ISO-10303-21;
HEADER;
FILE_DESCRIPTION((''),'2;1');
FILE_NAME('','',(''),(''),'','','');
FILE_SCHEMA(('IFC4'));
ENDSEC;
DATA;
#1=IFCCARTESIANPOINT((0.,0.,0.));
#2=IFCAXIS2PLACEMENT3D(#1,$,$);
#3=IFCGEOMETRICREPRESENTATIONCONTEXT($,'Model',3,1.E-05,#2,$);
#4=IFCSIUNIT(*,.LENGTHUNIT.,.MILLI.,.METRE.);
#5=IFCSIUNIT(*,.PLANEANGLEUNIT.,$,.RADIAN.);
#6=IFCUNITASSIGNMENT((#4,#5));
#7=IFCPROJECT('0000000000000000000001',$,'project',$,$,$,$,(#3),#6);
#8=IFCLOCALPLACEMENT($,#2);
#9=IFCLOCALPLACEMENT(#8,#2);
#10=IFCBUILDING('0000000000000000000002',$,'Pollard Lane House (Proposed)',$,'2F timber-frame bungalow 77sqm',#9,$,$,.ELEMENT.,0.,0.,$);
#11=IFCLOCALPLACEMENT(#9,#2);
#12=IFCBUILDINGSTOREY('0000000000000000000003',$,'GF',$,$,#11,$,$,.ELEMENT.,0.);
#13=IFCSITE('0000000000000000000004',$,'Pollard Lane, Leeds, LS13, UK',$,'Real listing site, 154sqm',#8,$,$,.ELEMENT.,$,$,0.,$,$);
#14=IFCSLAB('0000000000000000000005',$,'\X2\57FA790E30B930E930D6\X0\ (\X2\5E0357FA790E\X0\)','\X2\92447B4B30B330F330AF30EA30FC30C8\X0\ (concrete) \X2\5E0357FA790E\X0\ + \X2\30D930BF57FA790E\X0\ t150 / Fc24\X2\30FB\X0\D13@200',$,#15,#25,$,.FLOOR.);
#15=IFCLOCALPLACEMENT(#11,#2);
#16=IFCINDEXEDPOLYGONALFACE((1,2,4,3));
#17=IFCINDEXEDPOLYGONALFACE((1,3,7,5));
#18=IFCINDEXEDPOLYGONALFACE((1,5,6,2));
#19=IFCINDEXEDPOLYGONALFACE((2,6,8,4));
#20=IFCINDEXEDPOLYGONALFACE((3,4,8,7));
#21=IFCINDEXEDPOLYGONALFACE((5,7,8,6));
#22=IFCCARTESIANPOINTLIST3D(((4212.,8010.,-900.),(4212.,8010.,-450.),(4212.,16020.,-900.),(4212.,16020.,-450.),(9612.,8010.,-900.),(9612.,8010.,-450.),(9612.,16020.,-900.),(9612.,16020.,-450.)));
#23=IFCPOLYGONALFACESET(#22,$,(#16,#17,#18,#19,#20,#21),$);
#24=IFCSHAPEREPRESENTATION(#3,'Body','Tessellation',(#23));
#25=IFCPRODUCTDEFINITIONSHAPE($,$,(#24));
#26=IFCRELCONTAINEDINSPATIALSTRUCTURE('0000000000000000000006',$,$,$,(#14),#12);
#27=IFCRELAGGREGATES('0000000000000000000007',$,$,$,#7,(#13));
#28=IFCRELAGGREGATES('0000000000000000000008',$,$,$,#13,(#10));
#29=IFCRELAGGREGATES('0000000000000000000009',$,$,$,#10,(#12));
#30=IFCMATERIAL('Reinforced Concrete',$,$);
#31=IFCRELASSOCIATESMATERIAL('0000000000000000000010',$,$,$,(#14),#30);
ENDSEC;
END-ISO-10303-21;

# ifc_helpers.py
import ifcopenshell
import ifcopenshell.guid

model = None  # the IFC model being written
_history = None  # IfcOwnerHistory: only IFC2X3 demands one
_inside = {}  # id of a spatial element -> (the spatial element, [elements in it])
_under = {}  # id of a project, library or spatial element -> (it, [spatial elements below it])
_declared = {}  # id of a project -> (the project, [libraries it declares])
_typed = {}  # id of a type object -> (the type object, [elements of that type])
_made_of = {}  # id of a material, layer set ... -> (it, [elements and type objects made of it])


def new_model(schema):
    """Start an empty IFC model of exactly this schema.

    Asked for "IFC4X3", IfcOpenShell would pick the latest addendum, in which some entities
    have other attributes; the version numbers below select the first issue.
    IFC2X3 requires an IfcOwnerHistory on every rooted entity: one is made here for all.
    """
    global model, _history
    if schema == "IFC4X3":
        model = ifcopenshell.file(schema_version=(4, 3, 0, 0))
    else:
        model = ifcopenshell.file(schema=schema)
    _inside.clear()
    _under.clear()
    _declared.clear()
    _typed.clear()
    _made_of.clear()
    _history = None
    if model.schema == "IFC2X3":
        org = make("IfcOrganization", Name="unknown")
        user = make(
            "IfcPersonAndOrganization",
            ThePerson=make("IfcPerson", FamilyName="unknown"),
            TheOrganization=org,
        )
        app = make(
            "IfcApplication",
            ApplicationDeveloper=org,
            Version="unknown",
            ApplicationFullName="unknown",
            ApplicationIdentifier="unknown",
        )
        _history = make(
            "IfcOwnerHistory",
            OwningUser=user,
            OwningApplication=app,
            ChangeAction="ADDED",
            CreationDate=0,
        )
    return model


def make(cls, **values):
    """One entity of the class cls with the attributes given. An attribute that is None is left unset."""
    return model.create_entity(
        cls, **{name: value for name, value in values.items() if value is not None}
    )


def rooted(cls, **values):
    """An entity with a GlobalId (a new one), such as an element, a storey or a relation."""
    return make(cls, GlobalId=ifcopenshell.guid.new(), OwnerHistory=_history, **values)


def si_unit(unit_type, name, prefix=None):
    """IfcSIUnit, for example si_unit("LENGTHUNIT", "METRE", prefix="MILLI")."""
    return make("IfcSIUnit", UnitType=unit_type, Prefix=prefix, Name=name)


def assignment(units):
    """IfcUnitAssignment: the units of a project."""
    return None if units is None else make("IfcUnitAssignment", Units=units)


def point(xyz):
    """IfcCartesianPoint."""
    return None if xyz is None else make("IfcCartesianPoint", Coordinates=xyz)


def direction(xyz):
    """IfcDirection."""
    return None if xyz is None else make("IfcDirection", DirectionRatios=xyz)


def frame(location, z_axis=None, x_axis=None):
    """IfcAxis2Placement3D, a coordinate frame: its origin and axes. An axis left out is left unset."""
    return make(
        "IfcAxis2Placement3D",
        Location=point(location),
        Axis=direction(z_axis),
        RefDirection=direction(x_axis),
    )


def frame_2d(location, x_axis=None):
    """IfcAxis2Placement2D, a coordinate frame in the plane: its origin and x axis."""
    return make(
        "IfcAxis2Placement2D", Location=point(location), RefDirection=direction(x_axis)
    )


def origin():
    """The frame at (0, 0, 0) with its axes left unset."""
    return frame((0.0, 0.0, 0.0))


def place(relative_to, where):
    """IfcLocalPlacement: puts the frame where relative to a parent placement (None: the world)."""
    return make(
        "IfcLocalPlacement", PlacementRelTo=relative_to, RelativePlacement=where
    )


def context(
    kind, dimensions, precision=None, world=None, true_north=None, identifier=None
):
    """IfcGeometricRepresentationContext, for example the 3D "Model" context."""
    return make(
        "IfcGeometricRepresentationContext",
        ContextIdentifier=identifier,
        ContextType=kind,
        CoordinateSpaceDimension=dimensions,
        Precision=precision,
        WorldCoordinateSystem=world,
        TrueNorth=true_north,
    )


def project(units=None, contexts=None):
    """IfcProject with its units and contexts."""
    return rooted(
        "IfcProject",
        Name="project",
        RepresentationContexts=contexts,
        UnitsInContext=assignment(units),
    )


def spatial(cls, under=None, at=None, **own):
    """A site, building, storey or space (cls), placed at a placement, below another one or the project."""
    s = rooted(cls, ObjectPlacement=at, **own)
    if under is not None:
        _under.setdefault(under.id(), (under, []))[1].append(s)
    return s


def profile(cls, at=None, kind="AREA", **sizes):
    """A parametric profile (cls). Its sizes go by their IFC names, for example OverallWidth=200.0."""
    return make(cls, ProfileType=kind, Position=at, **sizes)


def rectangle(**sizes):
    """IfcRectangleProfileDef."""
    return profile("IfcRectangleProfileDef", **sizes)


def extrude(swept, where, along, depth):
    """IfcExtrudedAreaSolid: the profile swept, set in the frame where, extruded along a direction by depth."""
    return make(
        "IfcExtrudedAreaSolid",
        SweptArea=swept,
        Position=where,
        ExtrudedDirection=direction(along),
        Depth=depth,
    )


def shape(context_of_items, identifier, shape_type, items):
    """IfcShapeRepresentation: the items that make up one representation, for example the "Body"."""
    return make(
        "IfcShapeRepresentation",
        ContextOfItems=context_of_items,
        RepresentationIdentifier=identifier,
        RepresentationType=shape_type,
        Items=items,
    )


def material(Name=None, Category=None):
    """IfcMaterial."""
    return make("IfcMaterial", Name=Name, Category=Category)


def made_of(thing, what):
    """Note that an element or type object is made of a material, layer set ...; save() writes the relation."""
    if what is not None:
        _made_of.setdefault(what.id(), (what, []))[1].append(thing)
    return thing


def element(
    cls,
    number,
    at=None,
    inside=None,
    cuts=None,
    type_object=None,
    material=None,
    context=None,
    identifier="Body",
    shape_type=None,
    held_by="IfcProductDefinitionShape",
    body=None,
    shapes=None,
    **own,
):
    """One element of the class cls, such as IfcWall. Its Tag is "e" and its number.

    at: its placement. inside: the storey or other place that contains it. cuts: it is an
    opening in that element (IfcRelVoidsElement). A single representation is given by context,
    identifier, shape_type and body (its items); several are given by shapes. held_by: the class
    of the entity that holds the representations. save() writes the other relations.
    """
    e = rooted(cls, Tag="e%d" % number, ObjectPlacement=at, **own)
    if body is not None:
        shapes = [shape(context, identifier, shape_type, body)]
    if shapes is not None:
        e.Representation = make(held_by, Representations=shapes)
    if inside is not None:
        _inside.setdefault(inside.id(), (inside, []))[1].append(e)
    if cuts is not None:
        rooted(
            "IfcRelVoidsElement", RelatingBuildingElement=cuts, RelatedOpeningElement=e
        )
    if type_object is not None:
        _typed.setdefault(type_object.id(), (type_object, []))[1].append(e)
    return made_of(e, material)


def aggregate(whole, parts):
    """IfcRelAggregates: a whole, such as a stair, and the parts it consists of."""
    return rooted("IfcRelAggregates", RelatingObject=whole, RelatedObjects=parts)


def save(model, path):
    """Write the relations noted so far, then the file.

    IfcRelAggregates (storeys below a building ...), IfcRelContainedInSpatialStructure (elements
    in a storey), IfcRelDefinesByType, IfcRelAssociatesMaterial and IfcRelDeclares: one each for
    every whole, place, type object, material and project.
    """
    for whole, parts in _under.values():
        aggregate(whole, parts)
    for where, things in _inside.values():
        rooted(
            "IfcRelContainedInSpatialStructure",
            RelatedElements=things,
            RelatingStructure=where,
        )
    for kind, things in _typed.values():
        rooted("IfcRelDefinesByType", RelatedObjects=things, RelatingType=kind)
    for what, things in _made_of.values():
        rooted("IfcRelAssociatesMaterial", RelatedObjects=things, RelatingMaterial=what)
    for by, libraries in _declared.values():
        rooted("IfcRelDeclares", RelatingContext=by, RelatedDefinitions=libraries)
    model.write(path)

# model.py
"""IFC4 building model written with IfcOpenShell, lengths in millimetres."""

from ifc_helpers import new_model, si_unit, frame, frame_2d, origin, place, context, project, spatial, rectangle, extrude, material, element, save


model = new_model("IFC4")

# Units and contexts
model_context = context("Model", 3, precision=1e-05, world=origin())
ifc_project = project(units=[si_unit("LENGTHUNIT", "METRE", prefix="MILLI"), si_unit("PLANEANGLEUNIT", "RADIAN")], contexts=[model_context])

# Site, building, storey
site_placement = place(None, origin())
site = spatial("IfcSite", under=ifc_project, at=site_placement, Name="Pollard Lane, Leeds, LS13, UK", ObjectType="Real listing site, 154sqm", CompositionType="ELEMENT", RefElevation=0.0)
building_placement = place(site_placement, origin())
building = spatial("IfcBuilding", under=site, at=building_placement, Name="Pollard Lane House (Proposed)", ObjectType="2F timber-frame bungalow 77sqm", CompositionType="ELEMENT", ElevationOfRefHeight=0.0, ElevationOfTerrain=0.0)
storey_placement = place(building_placement, origin())
storey = spatial("IfcBuildingStorey", under=building, at=storey_placement, Name="GF", CompositionType="ELEMENT", Elevation=0.0)

# Slab
ifc_material_1 = material(Name="Reinforced Concrete")
slab_1_placement = place(storey_placement, frame((2106.0, 4005.0, -450.0)))
element("IfcSlab", 1, at=slab_1_placement, inside=storey, material=ifc_material_1, Name="基礎スラブ (布基礎)", Description="鉄筋コンクリート (concrete) 布基礎 + ベタ基礎 t150 / Fc24・D13@200", PredefinedType="FLOOR", context=model_context, shape_type="SweptSolid", body=[
    extrude(rectangle(XDim=5400.0, YDim=8010.0, at=frame_2d((2700.0, 4005.0))), frame((2106.0, 4005.0, -450.0)), (0.0, 0.0, 1.0), 450.0),
])

save(model, "model.ifc")
